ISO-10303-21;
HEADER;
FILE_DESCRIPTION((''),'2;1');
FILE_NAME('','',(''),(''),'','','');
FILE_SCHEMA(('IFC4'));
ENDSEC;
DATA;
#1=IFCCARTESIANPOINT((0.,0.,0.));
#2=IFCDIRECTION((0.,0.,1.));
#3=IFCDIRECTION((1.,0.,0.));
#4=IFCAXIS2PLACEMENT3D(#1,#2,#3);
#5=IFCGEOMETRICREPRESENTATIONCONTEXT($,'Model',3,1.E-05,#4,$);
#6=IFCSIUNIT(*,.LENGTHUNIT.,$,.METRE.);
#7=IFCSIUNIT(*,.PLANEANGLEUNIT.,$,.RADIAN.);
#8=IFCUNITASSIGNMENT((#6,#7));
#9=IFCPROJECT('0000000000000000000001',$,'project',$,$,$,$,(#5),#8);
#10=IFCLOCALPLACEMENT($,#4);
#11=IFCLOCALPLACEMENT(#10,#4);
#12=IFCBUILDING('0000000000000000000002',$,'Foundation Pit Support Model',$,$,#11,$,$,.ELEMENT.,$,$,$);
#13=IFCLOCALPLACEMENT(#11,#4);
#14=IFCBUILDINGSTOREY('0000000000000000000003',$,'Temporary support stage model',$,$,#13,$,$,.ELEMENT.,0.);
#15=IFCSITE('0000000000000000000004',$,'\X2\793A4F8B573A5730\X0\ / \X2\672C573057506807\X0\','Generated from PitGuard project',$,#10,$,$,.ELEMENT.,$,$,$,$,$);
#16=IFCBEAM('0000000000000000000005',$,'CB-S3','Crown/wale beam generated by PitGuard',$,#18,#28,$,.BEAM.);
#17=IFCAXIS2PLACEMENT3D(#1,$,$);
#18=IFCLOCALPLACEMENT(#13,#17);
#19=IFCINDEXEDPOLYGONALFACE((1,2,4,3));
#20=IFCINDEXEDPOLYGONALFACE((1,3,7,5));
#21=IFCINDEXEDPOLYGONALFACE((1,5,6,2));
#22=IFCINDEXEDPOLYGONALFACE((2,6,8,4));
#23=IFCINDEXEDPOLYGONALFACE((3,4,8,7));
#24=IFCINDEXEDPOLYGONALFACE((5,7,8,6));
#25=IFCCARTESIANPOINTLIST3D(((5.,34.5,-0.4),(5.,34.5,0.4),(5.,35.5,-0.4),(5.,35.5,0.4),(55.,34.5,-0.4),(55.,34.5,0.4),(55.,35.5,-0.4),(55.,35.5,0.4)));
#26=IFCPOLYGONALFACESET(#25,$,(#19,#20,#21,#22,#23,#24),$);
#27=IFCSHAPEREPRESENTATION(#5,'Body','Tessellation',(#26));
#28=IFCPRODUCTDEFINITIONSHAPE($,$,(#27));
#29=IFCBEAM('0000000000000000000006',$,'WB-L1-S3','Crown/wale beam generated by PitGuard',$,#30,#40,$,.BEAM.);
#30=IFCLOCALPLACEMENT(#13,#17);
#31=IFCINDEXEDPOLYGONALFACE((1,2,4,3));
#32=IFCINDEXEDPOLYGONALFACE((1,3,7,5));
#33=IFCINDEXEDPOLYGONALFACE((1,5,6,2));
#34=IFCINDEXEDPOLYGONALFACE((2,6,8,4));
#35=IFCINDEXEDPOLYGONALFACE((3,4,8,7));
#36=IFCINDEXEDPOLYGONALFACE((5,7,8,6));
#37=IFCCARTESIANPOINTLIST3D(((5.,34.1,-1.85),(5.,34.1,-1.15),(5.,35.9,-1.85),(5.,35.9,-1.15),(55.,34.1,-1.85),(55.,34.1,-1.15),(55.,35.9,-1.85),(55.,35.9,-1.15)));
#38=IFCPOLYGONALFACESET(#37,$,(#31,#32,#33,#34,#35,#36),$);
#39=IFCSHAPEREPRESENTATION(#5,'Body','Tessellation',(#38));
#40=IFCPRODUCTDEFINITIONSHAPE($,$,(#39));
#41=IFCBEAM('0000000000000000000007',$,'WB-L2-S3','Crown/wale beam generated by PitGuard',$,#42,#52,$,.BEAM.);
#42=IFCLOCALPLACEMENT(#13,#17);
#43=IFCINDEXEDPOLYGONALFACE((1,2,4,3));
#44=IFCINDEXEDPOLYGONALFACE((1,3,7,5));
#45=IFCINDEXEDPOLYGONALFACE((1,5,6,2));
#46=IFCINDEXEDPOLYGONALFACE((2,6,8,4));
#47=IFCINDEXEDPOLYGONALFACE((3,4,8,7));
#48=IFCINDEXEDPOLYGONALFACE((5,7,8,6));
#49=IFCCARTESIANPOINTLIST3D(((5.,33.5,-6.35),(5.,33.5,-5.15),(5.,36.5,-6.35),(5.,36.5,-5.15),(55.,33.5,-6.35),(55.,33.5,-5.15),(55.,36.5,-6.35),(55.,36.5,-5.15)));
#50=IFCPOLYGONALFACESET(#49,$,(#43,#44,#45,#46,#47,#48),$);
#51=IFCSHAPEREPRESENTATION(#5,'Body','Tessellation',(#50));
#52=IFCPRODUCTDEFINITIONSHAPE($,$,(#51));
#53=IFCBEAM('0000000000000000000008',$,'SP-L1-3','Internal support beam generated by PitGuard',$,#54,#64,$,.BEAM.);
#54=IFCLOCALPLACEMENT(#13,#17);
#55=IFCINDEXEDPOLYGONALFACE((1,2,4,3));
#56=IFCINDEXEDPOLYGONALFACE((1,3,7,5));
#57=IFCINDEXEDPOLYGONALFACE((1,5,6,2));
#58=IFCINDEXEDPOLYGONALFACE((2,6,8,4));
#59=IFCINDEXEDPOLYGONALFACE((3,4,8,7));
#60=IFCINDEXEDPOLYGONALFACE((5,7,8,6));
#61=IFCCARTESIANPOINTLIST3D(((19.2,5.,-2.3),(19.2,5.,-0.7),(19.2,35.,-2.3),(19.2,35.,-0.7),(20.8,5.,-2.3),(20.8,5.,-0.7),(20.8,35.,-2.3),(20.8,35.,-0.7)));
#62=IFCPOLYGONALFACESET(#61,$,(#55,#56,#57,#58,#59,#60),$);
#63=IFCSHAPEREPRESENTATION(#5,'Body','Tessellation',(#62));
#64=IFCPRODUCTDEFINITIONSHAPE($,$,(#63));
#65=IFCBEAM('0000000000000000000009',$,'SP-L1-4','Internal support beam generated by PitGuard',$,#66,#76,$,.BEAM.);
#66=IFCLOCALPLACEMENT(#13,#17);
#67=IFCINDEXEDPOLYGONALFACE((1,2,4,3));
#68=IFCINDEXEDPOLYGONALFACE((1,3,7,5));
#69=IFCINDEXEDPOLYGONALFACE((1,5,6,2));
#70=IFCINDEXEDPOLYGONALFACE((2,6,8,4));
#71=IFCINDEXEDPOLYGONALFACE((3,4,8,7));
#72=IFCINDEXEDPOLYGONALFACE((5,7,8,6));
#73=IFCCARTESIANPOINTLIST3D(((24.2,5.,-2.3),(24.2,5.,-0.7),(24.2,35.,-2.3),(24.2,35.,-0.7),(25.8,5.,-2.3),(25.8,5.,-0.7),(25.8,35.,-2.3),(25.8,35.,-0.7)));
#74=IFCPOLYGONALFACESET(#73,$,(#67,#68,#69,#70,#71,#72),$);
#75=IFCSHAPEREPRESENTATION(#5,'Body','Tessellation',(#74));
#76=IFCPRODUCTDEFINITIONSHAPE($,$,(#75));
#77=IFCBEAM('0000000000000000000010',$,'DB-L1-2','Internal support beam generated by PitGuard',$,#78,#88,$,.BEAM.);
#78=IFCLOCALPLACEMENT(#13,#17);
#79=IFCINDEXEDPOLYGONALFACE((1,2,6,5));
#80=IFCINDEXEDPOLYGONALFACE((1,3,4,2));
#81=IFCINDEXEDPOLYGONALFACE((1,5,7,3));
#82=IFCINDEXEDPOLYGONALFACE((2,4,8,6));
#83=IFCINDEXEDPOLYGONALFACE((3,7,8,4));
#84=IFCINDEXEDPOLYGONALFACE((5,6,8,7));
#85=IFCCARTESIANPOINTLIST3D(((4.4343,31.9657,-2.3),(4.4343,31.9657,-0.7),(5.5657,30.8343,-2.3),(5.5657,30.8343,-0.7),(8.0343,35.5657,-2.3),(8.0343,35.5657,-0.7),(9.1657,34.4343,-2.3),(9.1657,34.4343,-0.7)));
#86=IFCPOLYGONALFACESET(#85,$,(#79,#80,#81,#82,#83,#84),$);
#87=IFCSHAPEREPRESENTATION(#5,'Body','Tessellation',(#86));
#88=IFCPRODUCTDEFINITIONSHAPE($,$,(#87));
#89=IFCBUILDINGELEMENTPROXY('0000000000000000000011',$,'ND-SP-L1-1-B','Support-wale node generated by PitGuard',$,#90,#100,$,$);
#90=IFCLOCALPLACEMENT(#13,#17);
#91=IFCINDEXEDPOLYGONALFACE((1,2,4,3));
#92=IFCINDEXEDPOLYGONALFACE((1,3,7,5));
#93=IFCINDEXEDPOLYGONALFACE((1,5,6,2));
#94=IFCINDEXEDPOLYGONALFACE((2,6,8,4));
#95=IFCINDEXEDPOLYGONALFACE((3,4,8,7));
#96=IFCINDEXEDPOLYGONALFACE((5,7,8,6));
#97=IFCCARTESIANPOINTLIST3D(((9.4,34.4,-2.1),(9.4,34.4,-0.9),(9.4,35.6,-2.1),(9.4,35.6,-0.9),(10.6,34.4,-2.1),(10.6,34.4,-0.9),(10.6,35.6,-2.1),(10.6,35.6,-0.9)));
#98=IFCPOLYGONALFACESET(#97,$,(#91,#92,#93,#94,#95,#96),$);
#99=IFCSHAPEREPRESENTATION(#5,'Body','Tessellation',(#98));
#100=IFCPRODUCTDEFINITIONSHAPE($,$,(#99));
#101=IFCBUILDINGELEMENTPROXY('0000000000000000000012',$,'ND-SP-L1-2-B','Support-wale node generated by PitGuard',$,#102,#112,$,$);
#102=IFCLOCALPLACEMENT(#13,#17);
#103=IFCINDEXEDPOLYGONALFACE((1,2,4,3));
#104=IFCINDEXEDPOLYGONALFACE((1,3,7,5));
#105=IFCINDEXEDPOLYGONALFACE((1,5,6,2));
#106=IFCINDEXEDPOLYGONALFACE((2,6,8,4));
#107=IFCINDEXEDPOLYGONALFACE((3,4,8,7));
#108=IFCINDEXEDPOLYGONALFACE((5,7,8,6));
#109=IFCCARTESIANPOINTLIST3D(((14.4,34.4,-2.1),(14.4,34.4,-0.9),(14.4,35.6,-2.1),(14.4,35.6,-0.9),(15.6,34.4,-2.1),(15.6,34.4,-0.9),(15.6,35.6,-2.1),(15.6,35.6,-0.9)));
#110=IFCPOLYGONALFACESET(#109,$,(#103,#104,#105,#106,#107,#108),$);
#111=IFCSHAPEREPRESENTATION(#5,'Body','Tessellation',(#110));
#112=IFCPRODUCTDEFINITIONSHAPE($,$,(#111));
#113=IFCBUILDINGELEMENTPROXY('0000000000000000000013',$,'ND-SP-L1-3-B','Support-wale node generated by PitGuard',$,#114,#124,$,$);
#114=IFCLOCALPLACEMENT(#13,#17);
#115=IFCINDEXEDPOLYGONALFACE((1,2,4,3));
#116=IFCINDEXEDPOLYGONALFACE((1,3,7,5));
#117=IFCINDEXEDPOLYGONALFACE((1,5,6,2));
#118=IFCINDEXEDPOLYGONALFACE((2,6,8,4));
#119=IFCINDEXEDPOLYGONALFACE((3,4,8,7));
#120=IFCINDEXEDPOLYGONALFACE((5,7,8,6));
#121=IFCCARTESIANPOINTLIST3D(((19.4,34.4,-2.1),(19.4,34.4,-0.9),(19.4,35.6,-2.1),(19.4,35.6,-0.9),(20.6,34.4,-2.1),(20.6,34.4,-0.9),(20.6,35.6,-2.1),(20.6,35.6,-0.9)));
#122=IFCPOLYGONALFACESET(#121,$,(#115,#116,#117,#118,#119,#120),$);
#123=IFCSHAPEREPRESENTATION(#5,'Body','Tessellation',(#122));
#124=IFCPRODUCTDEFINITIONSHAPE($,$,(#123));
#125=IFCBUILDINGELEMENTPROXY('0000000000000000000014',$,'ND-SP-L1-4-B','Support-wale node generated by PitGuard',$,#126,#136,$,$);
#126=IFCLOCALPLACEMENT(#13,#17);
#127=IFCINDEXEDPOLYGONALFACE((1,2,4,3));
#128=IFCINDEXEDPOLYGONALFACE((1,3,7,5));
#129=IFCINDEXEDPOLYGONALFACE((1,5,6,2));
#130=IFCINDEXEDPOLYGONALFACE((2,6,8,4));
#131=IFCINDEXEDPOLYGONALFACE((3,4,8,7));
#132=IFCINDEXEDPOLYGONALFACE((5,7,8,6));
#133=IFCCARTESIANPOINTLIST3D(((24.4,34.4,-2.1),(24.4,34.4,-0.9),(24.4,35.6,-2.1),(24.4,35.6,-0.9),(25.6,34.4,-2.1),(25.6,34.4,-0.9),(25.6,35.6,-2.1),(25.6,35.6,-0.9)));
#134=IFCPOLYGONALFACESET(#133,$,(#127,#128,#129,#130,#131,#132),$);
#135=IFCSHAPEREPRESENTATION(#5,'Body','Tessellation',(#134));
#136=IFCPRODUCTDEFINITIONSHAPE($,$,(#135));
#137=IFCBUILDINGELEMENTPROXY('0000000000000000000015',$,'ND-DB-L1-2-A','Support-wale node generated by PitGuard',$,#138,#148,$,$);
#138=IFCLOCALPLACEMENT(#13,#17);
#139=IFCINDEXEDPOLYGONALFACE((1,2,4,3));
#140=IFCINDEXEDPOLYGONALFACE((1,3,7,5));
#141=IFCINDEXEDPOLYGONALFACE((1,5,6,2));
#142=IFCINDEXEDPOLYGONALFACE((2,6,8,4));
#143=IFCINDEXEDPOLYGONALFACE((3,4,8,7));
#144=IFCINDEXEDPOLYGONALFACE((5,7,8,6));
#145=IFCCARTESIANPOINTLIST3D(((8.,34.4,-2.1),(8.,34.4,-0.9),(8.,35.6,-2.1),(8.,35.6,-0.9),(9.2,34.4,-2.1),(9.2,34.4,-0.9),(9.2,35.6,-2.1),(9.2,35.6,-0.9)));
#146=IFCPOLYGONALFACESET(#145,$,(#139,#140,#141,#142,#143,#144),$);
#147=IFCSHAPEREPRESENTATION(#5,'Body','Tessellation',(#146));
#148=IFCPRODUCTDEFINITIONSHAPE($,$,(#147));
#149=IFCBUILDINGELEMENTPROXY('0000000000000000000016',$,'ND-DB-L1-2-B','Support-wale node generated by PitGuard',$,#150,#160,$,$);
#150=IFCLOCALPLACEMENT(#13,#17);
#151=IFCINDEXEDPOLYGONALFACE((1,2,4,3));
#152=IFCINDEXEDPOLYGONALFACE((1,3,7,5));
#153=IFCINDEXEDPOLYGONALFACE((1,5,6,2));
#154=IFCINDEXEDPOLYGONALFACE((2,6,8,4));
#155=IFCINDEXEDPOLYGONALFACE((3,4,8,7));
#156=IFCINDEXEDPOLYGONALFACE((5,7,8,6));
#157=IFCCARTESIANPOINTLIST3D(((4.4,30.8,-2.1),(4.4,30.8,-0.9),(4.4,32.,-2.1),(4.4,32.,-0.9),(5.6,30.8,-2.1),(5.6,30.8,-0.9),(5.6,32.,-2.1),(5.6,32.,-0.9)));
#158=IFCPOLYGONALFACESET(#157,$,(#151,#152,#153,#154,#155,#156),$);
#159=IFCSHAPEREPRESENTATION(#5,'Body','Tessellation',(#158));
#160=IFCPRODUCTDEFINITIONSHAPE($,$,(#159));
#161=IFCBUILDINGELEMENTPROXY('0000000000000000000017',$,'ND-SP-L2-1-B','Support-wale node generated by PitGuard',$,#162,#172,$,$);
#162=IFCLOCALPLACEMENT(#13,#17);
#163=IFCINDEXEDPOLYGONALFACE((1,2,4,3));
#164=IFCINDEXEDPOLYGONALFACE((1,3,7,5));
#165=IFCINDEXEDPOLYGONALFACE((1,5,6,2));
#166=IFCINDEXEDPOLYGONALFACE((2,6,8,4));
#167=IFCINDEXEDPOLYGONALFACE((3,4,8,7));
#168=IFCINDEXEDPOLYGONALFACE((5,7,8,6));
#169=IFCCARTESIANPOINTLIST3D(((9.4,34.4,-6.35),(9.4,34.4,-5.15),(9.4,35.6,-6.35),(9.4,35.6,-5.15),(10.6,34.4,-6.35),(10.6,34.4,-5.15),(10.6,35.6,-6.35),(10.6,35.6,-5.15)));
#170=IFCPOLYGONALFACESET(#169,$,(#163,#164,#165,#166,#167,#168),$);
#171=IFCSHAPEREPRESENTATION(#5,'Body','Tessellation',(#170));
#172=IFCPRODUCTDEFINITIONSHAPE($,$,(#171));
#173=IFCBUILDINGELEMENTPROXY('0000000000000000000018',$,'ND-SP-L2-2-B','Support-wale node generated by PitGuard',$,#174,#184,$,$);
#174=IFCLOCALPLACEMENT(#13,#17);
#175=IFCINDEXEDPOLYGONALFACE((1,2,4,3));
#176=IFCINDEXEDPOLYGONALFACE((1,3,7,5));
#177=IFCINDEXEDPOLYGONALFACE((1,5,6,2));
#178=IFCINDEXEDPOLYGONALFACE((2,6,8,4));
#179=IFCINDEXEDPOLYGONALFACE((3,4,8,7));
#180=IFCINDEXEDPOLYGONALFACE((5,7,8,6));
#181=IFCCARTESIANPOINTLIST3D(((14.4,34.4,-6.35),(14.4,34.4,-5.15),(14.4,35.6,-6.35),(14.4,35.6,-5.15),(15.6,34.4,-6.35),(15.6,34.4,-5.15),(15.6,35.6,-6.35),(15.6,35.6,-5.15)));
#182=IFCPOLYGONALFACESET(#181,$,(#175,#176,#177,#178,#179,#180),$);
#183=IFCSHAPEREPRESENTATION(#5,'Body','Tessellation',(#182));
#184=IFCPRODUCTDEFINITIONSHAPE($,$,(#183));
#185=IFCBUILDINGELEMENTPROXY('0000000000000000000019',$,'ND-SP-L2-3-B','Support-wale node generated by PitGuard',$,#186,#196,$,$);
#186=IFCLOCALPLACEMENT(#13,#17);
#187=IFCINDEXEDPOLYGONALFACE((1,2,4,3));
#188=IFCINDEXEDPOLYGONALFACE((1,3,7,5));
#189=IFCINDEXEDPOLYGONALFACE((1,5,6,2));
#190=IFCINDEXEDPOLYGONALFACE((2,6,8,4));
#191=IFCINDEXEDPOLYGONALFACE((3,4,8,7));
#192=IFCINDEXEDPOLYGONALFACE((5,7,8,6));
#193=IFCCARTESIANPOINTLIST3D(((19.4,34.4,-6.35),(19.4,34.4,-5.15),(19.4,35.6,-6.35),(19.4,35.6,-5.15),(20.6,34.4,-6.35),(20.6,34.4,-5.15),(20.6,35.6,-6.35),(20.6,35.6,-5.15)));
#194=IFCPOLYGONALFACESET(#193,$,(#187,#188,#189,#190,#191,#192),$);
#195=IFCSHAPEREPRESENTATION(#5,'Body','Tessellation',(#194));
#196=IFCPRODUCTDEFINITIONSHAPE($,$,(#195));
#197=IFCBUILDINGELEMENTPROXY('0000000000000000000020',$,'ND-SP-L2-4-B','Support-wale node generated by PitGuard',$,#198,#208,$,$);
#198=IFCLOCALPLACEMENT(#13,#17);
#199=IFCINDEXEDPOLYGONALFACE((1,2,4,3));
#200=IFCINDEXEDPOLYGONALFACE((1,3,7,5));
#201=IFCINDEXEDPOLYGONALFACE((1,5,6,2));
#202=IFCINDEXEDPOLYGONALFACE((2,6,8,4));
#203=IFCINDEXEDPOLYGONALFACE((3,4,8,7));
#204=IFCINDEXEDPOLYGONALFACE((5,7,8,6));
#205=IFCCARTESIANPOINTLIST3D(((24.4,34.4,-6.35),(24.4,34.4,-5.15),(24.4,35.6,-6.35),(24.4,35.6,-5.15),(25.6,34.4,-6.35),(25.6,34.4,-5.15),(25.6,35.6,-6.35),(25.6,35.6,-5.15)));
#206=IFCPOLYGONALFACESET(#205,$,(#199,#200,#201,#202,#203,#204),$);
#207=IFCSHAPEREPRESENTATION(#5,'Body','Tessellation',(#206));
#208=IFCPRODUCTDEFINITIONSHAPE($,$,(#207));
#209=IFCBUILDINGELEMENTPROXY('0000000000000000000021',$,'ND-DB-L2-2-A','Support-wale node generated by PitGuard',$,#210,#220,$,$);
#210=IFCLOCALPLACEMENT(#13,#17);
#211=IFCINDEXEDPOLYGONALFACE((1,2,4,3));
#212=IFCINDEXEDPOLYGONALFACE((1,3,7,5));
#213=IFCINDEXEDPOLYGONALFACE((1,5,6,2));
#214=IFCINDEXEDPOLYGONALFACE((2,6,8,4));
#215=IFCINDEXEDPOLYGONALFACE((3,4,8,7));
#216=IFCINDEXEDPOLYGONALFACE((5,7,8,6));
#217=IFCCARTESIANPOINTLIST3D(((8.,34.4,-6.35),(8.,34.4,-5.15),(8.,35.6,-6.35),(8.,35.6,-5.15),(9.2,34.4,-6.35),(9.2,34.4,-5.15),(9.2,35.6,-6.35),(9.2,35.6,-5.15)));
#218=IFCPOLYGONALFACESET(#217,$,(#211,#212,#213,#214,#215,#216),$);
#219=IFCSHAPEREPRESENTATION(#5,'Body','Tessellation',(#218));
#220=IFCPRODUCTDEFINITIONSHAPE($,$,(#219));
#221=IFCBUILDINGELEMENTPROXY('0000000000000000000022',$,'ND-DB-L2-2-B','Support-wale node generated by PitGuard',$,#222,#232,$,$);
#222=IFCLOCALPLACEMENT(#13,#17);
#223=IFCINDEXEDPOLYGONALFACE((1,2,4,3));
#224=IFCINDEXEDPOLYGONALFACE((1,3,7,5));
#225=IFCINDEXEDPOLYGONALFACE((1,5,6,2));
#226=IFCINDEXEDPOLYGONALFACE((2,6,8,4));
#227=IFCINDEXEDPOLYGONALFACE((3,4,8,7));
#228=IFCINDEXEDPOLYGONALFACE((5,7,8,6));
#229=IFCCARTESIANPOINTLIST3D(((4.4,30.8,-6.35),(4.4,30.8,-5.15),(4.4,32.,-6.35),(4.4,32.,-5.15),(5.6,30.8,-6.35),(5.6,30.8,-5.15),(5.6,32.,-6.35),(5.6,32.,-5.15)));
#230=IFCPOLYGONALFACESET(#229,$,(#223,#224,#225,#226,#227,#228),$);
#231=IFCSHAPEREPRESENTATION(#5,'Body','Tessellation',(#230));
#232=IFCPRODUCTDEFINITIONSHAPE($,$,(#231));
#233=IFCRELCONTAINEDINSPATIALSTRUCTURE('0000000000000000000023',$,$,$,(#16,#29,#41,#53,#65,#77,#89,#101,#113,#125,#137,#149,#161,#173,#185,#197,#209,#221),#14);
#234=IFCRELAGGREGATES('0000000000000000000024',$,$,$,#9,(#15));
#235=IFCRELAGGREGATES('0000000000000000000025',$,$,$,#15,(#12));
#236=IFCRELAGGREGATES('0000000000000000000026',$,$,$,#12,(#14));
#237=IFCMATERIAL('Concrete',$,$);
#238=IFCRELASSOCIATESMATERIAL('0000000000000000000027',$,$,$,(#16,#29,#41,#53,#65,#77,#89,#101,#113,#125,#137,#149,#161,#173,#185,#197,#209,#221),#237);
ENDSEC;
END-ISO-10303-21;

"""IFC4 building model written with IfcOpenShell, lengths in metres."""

from ifc_helpers import new_model, si_unit, frame, origin_with_axes, origin_2d, place, context, project, spatial, rectangle, extrude, material, element, save


model = new_model("IFC4")

# Units and contexts
model_context = context("Model", 3, precision=1e-05, world=origin_with_axes())
ifc_project = project(units=[si_unit("LENGTHUNIT", "METRE"), si_unit("PLANEANGLEUNIT", "RADIAN")], contexts=[model_context])

# Site, building, storey
site_placement = place(None, origin_with_axes())
site = spatial("IfcSite", under=ifc_project, at=site_placement, Name="示例场地 / 本地坐标", Description="Generated from PitGuard project", CompositionType="ELEMENT")
building_placement = place(site_placement, origin_with_axes())
building = spatial("IfcBuilding", under=site, at=building_placement, Name="Foundation Pit Support Model", CompositionType="ELEMENT")
storey_placement = place(building_placement, origin_with_axes())
storey = spatial("IfcBuildingStorey", under=building, at=storey_placement, Name="Temporary support stage model", CompositionType="ELEMENT", Elevation=0.0)

# Beams
ifc_material_1 = material(Name="Concrete")
beam_1_placement = place(storey_placement, frame((30.0, 35.0, -0.4), z_axis=(0.0, 0.0, 1.0), x_axis=(-1.0, 0.0, 0.0)))
element("IfcBeam", 1, at=beam_1_placement, inside=storey, material=ifc_material_1, Name="CB-S3", Description="Crown/wale beam generated by PitGuard", PredefinedType="BEAM", context=model_context, shape_type="SweptSolid", body=[
    extrude(rectangle(XDim=50.0, YDim=1.0, at=origin_2d()), origin_with_axes(), (0.0, 0.0, 1.0), 0.8),
])
beam_2_placement = place(storey_placement, frame((30.0, 35.0, -1.85), z_axis=(0.0, 0.0, 1.0), x_axis=(-1.0, 0.0, 0.0)))
element("IfcBeam", 2, at=beam_2_placement, inside=storey, material=ifc_material_1, Name="WB-L1-S3", Description="Crown/wale beam generated by PitGuard", PredefinedType="BEAM", context=model_context, shape_type="SweptSolid", body=[
    extrude(rectangle(XDim=50.0, YDim=1.8, at=origin_2d()), origin_with_axes(), (0.0, 0.0, 1.0), 0.7),
])
beam_3_placement = place(storey_placement, frame((30.0, 35.0, -6.35), z_axis=(0.0, 0.0, 1.0), x_axis=(-1.0, 0.0, 0.0)))
element("IfcBeam", 3, at=beam_3_placement, inside=storey, material=ifc_material_1, Name="WB-L2-S3", Description="Crown/wale beam generated by PitGuard", PredefinedType="BEAM", context=model_context, shape_type="SweptSolid", body=[
    extrude(rectangle(XDim=50.0, YDim=3.0, at=origin_2d()), origin_with_axes(), (0.0, 0.0, 1.0), 1.2),
])
for number, where, z_axis, x_axis, name in (
    (4, (20.0, 20.0, -2.3), (0.0, 0.0, 1.0), (0.0, 1.0, 0.0), "SP-L1-3"),
    (5, (25.0, 20.0, -2.3), (0.0, 0.0, 1.0), (0.0, 1.0, 0.0), "SP-L1-4"),
):
    element("IfcBeam", number, at=place(storey_placement, frame(where, z_axis=z_axis, x_axis=x_axis)), inside=storey, material=ifc_material_1, Name=name, Description="Internal support beam generated by PitGuard", PredefinedType="BEAM", context=model_context, shape_type="SweptSolid", body=[
        extrude(rectangle(XDim=30.0, YDim=1.6, at=origin_2d()), origin_with_axes(), (0.0, 0.0, 1.0), 1.6),
    ])
beam_4_placement = place(storey_placement, frame((6.8, 33.2, -2.3), z_axis=(0.0, 0.0, 1.0), x_axis=(-0.707107, -0.707107, 0.0)))
element("IfcBeam", 6, at=beam_4_placement, inside=storey, material=ifc_material_1, Name="DB-L1-2", Description="Internal support beam generated by PitGuard", PredefinedType="BEAM", context=model_context, shape_type="SweptSolid", body=[
    extrude(rectangle(XDim=5.0912, YDim=1.6, at=origin_2d()), origin_with_axes(), (0.0, 0.0, 1.0), 1.6),
])

# Building element proxies
for number, where, z_axis, x_axis, name in (
    (7, (10.0, 35.0, -2.1), (0.0, 0.0, 1.0), (1.0, 0.0, 0.0), "ND-SP-L1-1-B"),
    (8, (15.0, 35.0, -2.1), (0.0, 0.0, 1.0), (1.0, 0.0, 0.0), "ND-SP-L1-2-B"),
    (9, (20.0, 35.0, -2.1), (0.0, 0.0, 1.0), (1.0, 0.0, 0.0), "ND-SP-L1-3-B"),
    (10, (25.0, 35.0, -2.1), (0.0, 0.0, 1.0), (1.0, 0.0, 0.0), "ND-SP-L1-4-B"),
    (11, (8.6, 35.0, -2.1), (0.0, 0.0, 1.0), (1.0, 0.0, 0.0), "ND-DB-L1-2-A"),
    (12, (5.0, 31.4, -2.1), (0.0, 0.0, 1.0), (1.0, 0.0, 0.0), "ND-DB-L1-2-B"),
    (13, (10.0, 35.0, -6.35), (0.0, 0.0, 1.0), (1.0, 0.0, 0.0), "ND-SP-L2-1-B"),
    (14, (15.0, 35.0, -6.35), (0.0, 0.0, 1.0), (1.0, 0.0, 0.0), "ND-SP-L2-2-B"),
    (15, (20.0, 35.0, -6.35), (0.0, 0.0, 1.0), (1.0, 0.0, 0.0), "ND-SP-L2-3-B"),
    (16, (25.0, 35.0, -6.35), (0.0, 0.0, 1.0), (1.0, 0.0, 0.0), "ND-SP-L2-4-B"),
    (17, (8.6, 35.0, -6.35), (0.0, 0.0, 1.0), (1.0, 0.0, 0.0), "ND-DB-L2-2-A"),
    (18, (5.0, 31.4, -6.35), (0.0, 0.0, 1.0), (1.0, 0.0, 0.0), "ND-DB-L2-2-B"),
):
    element("IfcBuildingElementProxy", number, at=place(storey_placement, frame(where, z_axis=z_axis, x_axis=x_axis)), inside=storey, material=ifc_material_1, Name=name, Description="Support-wale node generated by PitGuard", context=model_context, shape_type="SweptSolid", body=[
        extrude(rectangle(XDim=1.2, YDim=1.2, at=origin_2d()), origin_with_axes(), (0.0, 0.0, 1.0), 1.2),
    ])

save(model, "model.ifc")
